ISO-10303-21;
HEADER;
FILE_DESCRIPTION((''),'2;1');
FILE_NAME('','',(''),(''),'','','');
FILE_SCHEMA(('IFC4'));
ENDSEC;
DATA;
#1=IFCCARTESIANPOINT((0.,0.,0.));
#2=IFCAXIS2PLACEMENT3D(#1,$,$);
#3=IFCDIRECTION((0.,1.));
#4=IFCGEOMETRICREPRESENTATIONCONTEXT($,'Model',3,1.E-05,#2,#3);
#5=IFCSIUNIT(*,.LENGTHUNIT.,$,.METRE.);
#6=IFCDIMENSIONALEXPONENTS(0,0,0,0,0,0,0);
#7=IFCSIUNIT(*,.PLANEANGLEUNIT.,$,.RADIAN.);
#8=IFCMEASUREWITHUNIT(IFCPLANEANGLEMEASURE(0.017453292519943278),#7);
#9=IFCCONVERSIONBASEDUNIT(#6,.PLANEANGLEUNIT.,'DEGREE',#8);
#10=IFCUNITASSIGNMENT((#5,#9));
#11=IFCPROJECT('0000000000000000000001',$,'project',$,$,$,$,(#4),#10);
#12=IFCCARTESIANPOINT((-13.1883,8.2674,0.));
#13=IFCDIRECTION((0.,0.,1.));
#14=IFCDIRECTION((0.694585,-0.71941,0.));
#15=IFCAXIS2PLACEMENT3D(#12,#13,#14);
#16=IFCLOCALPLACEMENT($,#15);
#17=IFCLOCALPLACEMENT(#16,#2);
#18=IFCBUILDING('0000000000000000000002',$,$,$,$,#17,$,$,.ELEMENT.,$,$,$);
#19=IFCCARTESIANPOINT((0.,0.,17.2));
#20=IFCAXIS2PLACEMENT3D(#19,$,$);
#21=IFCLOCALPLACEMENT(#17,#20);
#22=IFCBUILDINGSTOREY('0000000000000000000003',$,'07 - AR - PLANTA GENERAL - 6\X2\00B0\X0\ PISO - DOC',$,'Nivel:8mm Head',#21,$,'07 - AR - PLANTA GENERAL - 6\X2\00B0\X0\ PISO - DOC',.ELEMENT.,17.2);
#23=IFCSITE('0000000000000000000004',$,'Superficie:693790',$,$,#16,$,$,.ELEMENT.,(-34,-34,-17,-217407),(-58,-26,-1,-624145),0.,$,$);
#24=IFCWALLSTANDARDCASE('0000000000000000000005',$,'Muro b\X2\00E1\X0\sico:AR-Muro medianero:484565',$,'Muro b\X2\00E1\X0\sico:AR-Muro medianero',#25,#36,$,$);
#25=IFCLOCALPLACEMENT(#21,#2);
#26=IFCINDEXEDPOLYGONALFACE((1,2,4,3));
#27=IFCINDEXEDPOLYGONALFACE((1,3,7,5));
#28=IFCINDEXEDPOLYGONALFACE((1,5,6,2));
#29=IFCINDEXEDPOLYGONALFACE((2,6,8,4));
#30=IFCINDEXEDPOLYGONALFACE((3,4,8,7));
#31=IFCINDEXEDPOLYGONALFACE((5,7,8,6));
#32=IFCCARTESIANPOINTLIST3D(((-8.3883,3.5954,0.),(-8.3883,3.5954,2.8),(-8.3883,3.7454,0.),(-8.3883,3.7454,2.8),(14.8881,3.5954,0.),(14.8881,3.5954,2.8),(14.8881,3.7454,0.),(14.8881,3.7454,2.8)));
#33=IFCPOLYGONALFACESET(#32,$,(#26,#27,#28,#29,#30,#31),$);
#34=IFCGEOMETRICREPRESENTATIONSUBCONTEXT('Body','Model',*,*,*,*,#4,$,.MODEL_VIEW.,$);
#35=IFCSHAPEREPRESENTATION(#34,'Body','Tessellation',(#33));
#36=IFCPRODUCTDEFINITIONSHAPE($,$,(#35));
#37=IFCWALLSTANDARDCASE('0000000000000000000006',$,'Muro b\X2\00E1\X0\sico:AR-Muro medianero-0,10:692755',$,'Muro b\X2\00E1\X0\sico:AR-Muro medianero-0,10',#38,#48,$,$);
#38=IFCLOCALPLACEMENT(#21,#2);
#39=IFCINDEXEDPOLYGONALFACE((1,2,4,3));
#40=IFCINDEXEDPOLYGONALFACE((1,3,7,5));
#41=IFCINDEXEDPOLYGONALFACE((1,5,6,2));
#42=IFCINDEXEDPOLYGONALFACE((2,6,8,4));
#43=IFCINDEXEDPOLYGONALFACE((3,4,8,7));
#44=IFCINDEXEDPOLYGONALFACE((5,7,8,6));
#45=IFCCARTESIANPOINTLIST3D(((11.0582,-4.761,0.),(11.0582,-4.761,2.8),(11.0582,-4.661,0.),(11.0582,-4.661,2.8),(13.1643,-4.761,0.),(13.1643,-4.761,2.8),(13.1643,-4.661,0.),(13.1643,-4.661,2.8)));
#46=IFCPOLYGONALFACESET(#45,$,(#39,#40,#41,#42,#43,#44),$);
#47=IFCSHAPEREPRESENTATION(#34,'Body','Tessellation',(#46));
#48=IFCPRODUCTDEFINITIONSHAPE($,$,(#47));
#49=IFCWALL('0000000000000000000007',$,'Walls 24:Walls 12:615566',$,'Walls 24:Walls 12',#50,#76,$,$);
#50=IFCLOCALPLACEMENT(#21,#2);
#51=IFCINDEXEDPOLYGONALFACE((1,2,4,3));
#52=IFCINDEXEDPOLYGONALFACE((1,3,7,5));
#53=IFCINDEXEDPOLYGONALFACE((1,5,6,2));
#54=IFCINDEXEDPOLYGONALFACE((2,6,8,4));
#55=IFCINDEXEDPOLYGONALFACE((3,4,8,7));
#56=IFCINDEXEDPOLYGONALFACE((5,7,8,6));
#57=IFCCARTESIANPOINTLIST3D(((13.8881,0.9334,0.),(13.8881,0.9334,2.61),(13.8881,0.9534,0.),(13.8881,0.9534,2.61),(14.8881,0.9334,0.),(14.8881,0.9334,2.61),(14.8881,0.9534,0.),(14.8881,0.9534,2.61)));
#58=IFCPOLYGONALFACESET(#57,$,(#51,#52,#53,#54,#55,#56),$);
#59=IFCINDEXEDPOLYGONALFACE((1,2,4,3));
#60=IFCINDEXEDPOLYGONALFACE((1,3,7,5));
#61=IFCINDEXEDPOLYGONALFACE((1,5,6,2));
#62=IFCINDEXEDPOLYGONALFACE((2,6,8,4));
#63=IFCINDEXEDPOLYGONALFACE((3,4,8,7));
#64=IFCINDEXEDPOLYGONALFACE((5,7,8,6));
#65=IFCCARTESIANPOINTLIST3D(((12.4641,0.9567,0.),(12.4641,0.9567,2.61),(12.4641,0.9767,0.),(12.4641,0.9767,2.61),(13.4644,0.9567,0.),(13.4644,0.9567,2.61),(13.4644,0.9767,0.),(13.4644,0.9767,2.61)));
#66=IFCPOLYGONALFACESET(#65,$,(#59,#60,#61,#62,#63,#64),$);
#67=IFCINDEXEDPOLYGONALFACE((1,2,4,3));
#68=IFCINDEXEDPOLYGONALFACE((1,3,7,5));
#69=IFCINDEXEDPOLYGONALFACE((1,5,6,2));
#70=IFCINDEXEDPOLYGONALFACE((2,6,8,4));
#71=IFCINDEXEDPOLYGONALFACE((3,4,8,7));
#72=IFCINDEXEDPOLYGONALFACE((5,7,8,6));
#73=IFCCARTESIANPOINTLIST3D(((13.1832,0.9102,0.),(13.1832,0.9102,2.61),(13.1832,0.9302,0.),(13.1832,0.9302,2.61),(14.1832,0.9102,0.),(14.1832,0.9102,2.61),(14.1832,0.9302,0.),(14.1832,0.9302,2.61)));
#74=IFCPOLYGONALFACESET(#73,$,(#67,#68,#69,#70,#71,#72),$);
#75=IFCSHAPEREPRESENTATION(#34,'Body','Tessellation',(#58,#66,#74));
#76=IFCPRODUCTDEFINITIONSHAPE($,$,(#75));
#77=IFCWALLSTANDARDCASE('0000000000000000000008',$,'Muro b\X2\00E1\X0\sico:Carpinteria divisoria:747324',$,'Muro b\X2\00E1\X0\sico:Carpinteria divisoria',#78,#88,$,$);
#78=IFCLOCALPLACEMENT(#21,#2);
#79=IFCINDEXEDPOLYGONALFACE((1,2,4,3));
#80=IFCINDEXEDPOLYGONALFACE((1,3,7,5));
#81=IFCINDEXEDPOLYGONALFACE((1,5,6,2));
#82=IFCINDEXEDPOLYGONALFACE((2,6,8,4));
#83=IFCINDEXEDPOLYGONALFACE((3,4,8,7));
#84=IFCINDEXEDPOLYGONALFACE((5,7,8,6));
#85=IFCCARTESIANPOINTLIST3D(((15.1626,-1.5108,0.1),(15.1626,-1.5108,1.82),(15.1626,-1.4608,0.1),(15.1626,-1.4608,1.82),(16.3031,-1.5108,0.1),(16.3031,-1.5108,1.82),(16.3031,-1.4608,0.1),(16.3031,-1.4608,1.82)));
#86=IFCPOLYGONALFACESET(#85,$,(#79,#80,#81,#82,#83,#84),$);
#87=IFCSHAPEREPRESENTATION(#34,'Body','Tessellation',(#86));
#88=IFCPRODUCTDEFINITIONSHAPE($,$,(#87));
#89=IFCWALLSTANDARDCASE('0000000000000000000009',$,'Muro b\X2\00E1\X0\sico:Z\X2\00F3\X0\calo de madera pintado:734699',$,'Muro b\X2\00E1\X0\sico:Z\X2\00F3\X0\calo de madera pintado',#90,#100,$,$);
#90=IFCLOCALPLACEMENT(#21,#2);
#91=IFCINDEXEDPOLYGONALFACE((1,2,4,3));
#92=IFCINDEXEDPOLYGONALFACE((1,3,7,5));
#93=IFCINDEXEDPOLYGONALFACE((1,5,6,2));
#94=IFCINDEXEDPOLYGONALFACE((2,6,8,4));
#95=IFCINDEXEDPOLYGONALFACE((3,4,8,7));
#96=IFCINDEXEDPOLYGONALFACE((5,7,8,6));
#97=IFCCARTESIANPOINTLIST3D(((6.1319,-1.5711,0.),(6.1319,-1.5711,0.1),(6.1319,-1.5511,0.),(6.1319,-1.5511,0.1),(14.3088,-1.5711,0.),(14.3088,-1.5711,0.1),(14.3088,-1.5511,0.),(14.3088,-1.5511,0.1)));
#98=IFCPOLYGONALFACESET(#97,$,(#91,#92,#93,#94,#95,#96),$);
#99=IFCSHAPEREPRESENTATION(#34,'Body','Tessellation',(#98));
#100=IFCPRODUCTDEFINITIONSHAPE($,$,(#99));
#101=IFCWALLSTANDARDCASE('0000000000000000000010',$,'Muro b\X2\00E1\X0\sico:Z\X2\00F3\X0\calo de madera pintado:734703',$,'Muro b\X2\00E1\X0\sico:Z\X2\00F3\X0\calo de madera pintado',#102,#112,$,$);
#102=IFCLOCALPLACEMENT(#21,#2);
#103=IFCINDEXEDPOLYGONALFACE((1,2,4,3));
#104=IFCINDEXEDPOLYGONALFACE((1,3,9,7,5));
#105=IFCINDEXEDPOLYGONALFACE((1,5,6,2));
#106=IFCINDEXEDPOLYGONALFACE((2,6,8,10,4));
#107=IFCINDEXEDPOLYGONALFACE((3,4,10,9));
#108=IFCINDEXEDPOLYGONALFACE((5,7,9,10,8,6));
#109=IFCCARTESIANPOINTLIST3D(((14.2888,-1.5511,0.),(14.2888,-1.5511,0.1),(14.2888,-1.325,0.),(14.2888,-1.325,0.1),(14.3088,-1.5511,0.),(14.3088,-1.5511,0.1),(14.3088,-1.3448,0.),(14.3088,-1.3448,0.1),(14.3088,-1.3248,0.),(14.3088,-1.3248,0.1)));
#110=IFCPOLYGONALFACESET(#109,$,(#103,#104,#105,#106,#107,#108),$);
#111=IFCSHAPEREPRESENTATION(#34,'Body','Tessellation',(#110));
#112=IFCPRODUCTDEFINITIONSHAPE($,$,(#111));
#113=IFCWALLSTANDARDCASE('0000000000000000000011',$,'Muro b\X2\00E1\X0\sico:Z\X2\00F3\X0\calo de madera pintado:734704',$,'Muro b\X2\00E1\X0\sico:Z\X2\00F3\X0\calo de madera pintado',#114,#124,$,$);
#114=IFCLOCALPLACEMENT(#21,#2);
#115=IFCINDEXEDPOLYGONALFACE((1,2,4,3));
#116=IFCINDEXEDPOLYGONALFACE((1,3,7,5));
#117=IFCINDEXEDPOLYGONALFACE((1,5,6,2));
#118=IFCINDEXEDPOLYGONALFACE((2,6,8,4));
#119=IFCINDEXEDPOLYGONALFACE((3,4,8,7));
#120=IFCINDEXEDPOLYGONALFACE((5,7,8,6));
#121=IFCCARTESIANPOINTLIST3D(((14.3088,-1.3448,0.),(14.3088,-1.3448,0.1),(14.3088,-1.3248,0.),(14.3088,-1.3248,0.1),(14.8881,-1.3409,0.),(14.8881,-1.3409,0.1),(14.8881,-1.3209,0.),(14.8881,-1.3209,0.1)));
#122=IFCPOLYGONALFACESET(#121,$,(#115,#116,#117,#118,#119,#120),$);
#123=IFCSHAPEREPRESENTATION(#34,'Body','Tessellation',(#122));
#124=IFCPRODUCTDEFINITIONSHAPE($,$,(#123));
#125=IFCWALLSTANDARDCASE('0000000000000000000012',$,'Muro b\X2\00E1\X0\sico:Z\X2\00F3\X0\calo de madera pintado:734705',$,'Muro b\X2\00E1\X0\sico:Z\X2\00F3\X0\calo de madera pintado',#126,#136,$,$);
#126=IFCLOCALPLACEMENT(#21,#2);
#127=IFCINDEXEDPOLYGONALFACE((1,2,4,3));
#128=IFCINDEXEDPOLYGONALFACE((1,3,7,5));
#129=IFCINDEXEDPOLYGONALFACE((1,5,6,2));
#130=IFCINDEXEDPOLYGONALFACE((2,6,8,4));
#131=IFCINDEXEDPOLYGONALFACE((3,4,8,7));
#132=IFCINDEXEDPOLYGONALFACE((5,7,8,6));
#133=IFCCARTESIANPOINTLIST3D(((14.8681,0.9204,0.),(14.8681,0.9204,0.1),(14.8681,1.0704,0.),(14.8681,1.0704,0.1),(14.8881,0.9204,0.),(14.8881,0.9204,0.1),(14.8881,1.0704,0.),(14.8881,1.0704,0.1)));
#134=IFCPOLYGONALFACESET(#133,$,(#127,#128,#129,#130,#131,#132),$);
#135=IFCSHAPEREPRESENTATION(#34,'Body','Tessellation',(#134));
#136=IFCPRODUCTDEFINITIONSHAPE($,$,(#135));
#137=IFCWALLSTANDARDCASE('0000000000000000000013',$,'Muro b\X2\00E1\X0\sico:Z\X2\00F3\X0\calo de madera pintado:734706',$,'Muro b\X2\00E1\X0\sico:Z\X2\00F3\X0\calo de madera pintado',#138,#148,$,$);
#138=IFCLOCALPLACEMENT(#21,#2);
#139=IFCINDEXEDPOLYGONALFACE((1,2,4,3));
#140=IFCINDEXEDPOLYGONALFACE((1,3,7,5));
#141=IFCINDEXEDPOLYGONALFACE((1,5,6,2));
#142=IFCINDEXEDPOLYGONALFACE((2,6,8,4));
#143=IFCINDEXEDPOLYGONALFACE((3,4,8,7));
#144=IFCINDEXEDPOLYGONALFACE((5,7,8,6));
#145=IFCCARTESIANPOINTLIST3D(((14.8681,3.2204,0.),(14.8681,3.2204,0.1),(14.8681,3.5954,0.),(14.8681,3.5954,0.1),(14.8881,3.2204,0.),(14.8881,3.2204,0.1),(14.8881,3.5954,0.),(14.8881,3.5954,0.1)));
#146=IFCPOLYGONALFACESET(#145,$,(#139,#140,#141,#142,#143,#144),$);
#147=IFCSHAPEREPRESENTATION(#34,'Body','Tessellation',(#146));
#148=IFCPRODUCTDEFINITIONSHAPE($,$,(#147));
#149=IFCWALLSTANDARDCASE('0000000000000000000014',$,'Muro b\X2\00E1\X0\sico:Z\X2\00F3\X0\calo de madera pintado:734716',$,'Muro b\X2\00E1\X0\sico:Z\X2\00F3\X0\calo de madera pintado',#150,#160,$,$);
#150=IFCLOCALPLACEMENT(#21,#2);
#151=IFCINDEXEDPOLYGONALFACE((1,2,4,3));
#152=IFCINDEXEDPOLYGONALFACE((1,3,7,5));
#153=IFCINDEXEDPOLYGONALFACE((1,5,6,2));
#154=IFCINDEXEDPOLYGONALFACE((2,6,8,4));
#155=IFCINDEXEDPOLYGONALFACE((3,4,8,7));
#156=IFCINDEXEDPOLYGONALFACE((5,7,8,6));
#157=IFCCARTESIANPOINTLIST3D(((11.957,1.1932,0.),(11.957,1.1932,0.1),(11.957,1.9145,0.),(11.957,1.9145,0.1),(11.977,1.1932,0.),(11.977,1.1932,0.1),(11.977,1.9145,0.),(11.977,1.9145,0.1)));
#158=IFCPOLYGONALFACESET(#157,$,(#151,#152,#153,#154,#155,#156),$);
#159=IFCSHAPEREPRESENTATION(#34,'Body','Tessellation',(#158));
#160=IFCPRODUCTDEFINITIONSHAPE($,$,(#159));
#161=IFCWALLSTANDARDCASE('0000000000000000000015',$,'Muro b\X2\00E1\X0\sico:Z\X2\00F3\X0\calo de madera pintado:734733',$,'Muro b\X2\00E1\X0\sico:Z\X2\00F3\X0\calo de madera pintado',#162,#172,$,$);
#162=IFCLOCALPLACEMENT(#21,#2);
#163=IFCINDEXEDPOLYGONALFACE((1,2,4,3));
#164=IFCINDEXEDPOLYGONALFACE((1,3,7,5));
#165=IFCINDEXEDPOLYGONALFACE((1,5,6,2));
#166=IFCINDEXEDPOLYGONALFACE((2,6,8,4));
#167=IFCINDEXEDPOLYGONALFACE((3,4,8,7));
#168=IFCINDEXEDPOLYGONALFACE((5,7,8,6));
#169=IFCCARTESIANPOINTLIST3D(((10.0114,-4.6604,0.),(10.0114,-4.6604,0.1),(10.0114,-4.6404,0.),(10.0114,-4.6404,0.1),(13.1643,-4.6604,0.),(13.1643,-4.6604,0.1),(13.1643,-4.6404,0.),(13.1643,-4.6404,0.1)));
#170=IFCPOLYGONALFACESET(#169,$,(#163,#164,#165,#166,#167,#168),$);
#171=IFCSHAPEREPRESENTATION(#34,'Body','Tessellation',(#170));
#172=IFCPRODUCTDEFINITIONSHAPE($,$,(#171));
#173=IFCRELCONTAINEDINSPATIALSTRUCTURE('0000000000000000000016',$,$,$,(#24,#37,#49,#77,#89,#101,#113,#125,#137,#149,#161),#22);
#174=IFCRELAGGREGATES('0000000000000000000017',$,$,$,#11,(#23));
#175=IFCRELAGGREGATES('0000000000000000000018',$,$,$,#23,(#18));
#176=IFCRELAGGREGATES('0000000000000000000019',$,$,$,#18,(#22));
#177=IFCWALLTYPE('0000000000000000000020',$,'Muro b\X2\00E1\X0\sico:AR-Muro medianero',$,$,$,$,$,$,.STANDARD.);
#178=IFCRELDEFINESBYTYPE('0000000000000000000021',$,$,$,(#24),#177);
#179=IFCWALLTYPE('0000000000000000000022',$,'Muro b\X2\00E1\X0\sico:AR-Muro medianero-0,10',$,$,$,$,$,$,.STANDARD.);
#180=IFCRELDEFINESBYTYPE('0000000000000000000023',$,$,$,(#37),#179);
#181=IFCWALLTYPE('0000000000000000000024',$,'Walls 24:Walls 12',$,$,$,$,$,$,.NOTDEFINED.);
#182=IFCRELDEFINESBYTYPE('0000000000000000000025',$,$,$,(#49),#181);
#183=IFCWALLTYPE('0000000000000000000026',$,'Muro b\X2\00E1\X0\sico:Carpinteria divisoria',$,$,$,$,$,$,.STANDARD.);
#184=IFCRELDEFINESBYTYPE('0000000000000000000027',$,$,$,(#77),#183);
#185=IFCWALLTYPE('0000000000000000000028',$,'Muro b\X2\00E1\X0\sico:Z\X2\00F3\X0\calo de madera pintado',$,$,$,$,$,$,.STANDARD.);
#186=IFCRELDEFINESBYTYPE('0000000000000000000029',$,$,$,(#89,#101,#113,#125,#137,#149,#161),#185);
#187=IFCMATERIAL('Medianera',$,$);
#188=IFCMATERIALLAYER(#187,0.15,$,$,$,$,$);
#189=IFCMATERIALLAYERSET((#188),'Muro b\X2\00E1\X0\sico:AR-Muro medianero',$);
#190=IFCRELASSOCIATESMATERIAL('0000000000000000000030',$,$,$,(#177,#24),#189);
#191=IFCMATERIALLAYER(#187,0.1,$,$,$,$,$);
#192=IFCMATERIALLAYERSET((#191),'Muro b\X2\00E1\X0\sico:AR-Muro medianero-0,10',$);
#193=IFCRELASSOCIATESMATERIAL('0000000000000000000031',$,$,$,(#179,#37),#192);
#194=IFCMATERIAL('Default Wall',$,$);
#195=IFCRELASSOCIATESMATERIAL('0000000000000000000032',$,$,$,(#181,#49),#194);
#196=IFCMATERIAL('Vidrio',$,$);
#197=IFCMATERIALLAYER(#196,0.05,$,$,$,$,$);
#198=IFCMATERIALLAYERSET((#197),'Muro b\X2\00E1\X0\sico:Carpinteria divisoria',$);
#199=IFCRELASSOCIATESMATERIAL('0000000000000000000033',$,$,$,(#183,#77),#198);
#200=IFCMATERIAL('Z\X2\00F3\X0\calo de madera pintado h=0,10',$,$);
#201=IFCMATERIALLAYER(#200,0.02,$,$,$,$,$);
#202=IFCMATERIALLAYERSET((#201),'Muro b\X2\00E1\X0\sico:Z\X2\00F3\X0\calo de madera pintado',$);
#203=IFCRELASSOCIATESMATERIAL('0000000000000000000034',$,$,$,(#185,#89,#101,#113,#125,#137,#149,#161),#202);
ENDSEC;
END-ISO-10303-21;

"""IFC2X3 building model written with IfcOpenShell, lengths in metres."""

from ifc_helpers import new_model, entity, si_unit, converted_unit, direction, frame, frame_2d, origin, origin_2d_with_axis, place, context, subcontext, project, spatial, polyline, rectangle, outline, extrude, material, layer, layer_set, layer_usage, type_object, element, save


model = new_model("IFC2X3")

# Units and contexts
model_context = context("Model", 3, precision=1e-05, world=origin(), true_north=direction((0.0, 1.0)))
body_context = subcontext(model_context, "Body", "Model", "MODEL_VIEW")
ifc_project = project(units=[si_unit("LENGTHUNIT", "METRE"), converted_unit("PLANEANGLEUNIT", "DEGREE", entity("IfcPlaneAngleMeasure", 0.017453292519943278), si_unit("PLANEANGLEUNIT", "RADIAN"), dimensions=[0, 0, 0, 0, 0, 0, 0])], contexts=[model_context])

# Site, building, storey
site_placement = place(None, frame((-13.1883, 8.2674, 0.0), z_axis=(0.0, 0.0, 1.0), x_axis=(0.694585, -0.71941, 0.0)))
site = spatial("IfcSite", under=ifc_project, at=site_placement, Name="Superficie:693790", CompositionType="ELEMENT", RefLatitude=(-34, -34, -17, -217407), RefLongitude=(-58, -26, -1, -624145), RefElevation=0.0)
building_placement = place(site_placement, origin())
building = spatial("IfcBuilding", under=site, at=building_placement, CompositionType="ELEMENT")
storey_placement = place(building_placement, frame((0.0, 0.0, 17.2)))
storey = spatial("IfcBuildingStorey", under=building, at=storey_placement, Name="07 - AR - PLANTA GENERAL - 6° PISO - DOC", ObjectType="Nivel:8mm Head", LongName="07 - AR - PLANTA GENERAL - 6° PISO - DOC", CompositionType="ELEMENT", Elevation=17.2)

# Shared definitions
ifc_material_1 = material(Name="Vidrio")

# Walls
ifc_material_2 = material(Name="Medianera")
ifc_layer_1 = layer(ifc_material_2, 0.15)
ifc_layer_set_1 = layer_set([ifc_layer_1], Name="Muro básico:AR-Muro medianero")
ifc_layer_usage_1 = layer_usage(ifc_layer_set_1, "AXIS2", "NEGATIVE", 0.075)
wall_type_1 = type_object("IfcWallType", Name="Muro básico:AR-Muro medianero", PredefinedType="STANDARD", material=ifc_layer_set_1)
wall_1_placement = place(storey_placement, frame((14.8881, 3.6704, 0.0), z_axis=(0.0, 0.0, 1.0), x_axis=(-1.0, 0.0, 0.0)))
element("IfcWallStandardCase", 1, at=wall_1_placement, inside=storey, type_object=wall_type_1, material=ifc_layer_usage_1, Name="Muro básico:AR-Muro medianero:484565", ObjectType="Muro básico:AR-Muro medianero", context=body_context, shape_type="SweptSolid", body=[
    extrude(rectangle(XDim=23.2763, YDim=0.15, at=frame_2d((11.6382, 0.0), x_axis=(-1.0, 0.0))), origin(), (0.0, 0.0, 1.0), 2.8),
])
ifc_layer_2 = layer(ifc_material_2, 0.1)
ifc_layer_set_2 = layer_set([ifc_layer_2], Name="Muro básico:AR-Muro medianero-0,10")
ifc_layer_usage_2 = layer_usage(ifc_layer_set_2, "AXIS2", "POSITIVE", -0.05)
wall_type_2 = type_object("IfcWallType", Name="Muro básico:AR-Muro medianero-0,10", PredefinedType="STANDARD", material=ifc_layer_set_2)
wall_2_placement = place(storey_placement, frame((13.1643, -4.711, 0.0), z_axis=(0.0, 0.0, 1.0), x_axis=(-1.0, 0.0, 0.0)))
element("IfcWallStandardCase", 2, at=wall_2_placement, inside=storey, type_object=wall_type_2, material=ifc_layer_usage_2, Name="Muro básico:AR-Muro medianero-0,10:692755", ObjectType="Muro básico:AR-Muro medianero-0,10", context=body_context, shape_type="SweptSolid", body=[
    extrude(rectangle(XDim=2.1061, YDim=0.1, at=frame_2d((1.053, 0.0), x_axis=(-1.0, 0.0))), origin(), (0.0, 0.0, 1.0), 2.8),
])
ifc_material_3 = material(Name="Default Wall")
wall_type_3 = type_object("IfcWallType", Name="Walls 24:Walls 12", PredefinedType="NOTDEFINED", material=ifc_material_3)
wall_3_placement = place(storey_placement, frame((12.4641, 0.9102, 0.0)))
element("IfcWall", 3, at=wall_3_placement, inside=storey, type_object=wall_type_3, material=ifc_material_3, Name="Walls 24:Walls 12:615566", ObjectType="Walls 24:Walls 12", context=body_context, shape_type="SweptSolid", body=[
    extrude(rectangle(XDim=1.0, YDim=0.02, at=origin_2d_with_axis()), frame((1.9239, 0.0332, 0.0), z_axis=(0.0, 0.0, 1.0), x_axis=(-1.0, 0.0, 0.0)), (0.0, 0.0, 1.0), 2.61),
    extrude(rectangle(XDim=1.0003, YDim=0.02, at=frame_2d((0.0, 0.0), x_axis=(1.0, 0.0))), frame((0.5001, 0.0565, 0.0), z_axis=(0.0, 0.0, 1.0), x_axis=(-1.0, 0.0, 0.0)), (0.0, 0.0, 1.0), 2.61),
    extrude(rectangle(XDim=1.0, YDim=0.02, at=origin_2d_with_axis()), frame((1.2191, 0.01, 0.0), z_axis=(0.0, 0.0, 1.0), x_axis=(-1.0, 0.0, 0.0)), (0.0, 0.0, 1.0), 2.61),
])
ifc_layer_3 = layer(ifc_material_1, 0.05)
ifc_layer_set_3 = layer_set([ifc_layer_3], Name="Muro básico:Carpinteria divisoria")
ifc_layer_usage_3 = layer_usage(ifc_layer_set_3, "AXIS2", "NEGATIVE", 0.025)
wall_type_4 = type_object("IfcWallType", Name="Muro básico:Carpinteria divisoria", PredefinedType="STANDARD", material=ifc_layer_set_3)
wall_4_placement = place(storey_placement, frame((15.1626, -1.4858, 0.1)))
element("IfcWallStandardCase", 4, at=wall_4_placement, inside=storey, type_object=wall_type_4, material=ifc_layer_usage_3, Name="Muro básico:Carpinteria divisoria:747324", ObjectType="Muro básico:Carpinteria divisoria", context=body_context, shape_type="SweptSolid", body=[
    extrude(rectangle(XDim=1.1405, YDim=0.05, at=frame_2d((0.5702, 0.0), x_axis=(-1.0, 0.0))), origin(), (0.0, 0.0, 1.0), 1.72),
])
ifc_material_4 = material(Name="Zócalo de madera pintado h=0,10")
ifc_layer_4 = layer(ifc_material_4, 0.02)
ifc_layer_set_4 = layer_set([ifc_layer_4], Name="Muro básico:Zócalo de madera pintado")
ifc_layer_usage_4 = layer_usage(ifc_layer_set_4, "AXIS2", "NEGATIVE", 0.01)
wall_type_5 = type_object("IfcWallType", Name="Muro básico:Zócalo de madera pintado", PredefinedType="STANDARD", material=ifc_layer_set_4)
wall_5_placement = place(storey_placement, frame((14.3088, -1.5611, 0.0), z_axis=(0.0, 0.0, 1.0), x_axis=(-1.0, 0.0, 0.0)))
element("IfcWallStandardCase", 5, at=wall_5_placement, inside=storey, type_object=wall_type_5, material=ifc_layer_usage_4, Name="Muro básico:Zócalo de madera pintado:734699", ObjectType="Muro básico:Zócalo de madera pintado", context=body_context, shape_type="SweptSolid", body=[
    extrude(rectangle(XDim=8.177, YDim=0.02, at=frame_2d((4.0885, 0.0), x_axis=(-1.0, 0.0))), origin(), (0.0, 0.0, 1.0), 0.1),
])
ifc_layer_usage_5 = layer_usage(ifc_layer_set_4, "AXIS2", "NEGATIVE", 0.01)
wall_6_placement = place(storey_placement, frame((14.2988, -1.3248, 0.0), z_axis=(0.0, 0.0, 1.0), x_axis=(0.0, -1.0, 0.0)))
element("IfcWallStandardCase", 6, at=wall_6_placement, inside=storey, type_object=wall_type_5, material=ifc_layer_usage_5, Name="Muro básico:Zócalo de madera pintado:734703", ObjectType="Muro básico:Zócalo de madera pintado", context=body_context, shape_type="SweptSolid", body=[
    extrude(outline(polyline([(0.2262, -0.01), (0.2262, 0.01), (0.02, 0.01), (0.0, 0.01), (0.0001, -0.01), (0.2262, -0.01)])), origin(), (0.0, 0.0, 1.0), 0.1),
])
ifc_layer_usage_6 = layer_usage(ifc_layer_set_4, "AXIS2", "NEGATIVE", 0.01)
wall_7_placement = place(storey_placement, frame((14.8881, -1.3309, 0.0), z_axis=(0.0, 0.0, 1.0), x_axis=(-0.999977, -0.006798, 0.0)))
element("IfcWallStandardCase", 7, at=wall_7_placement, inside=storey, type_object=wall_type_5, material=ifc_layer_usage_6, Name="Muro básico:Zócalo de madera pintado:734704", ObjectType="Muro básico:Zócalo de madera pintado", context=body_context, shape_type="SweptSolid", body=[
    extrude(outline(polyline([(0.5792, -0.01), (0.5794, 0.01), (0.0001, 0.01), (0.0, -0.01), (0.5792, -0.01)])), origin(), (0.0, 0.0, 1.0), 0.1),
])
ifc_layer_usage_7 = layer_usage(ifc_layer_set_4, "AXIS2", "NEGATIVE", 0.01)
wall_8_placement = place(storey_placement, frame((14.8781, 1.0704, 0.0), z_axis=(0.0, 0.0, 1.0), x_axis=(0.0, -1.0, 0.0)))
element("IfcWallStandardCase", 8, at=wall_8_placement, inside=storey, type_object=wall_type_5, material=ifc_layer_usage_7, Name="Muro básico:Zócalo de madera pintado:734705", ObjectType="Muro básico:Zócalo de madera pintado", context=body_context, shape_type="SweptSolid", body=[
    extrude(rectangle(XDim=0.15, YDim=0.02, at=frame_2d((0.075, 0.0), x_axis=(-1.0, 0.0))), origin(), (0.0, 0.0, 1.0), 0.1),
])
ifc_layer_usage_8 = layer_usage(ifc_layer_set_4, "AXIS2", "NEGATIVE", 0.01)
wall_9_placement = place(storey_placement, frame((14.8781, 3.5954, 0.0), z_axis=(0.0, 0.0, 1.0), x_axis=(0.0, -1.0, 0.0)))
element("IfcWallStandardCase", 9, at=wall_9_placement, inside=storey, type_object=wall_type_5, material=ifc_layer_usage_8, Name="Muro básico:Zócalo de madera pintado:734706", ObjectType="Muro básico:Zócalo de madera pintado", context=body_context, shape_type="SweptSolid", body=[
    extrude(rectangle(XDim=0.375, YDim=0.02, at=frame_2d((0.1875, 0.0), x_axis=(-1.0, 0.0))), origin(), (0.0, 0.0, 1.0), 0.1),
])
ifc_layer_usage_9 = layer_usage(ifc_layer_set_4, "AXIS2", "NEGATIVE", 0.01)
wall_10_placement = place(storey_placement, frame((11.967, 1.1932, 0.0), z_axis=(0.0, 0.0, 1.0), x_axis=(0.0, 1.0, 0.0)))
element("IfcWallStandardCase", 10, at=wall_10_placement, inside=storey, type_object=wall_type_5, material=ifc_layer_usage_9, Name="Muro básico:Zócalo de madera pintado:734716", ObjectType="Muro básico:Zócalo de madera pintado", context=body_context, shape_type="SweptSolid", body=[
    extrude(rectangle(XDim=0.7214, YDim=0.02, at=frame_2d((0.3607, 0.0), x_axis=(-1.0, 0.0))), origin(), (0.0, 0.0, 1.0), 0.1),
])
ifc_layer_usage_10 = layer_usage(ifc_layer_set_4, "AXIS2", "NEGATIVE", 0.01)
wall_11_placement = place(storey_placement, frame((13.1643, -4.6504, 0.0), z_axis=(0.0, 0.0, 1.0), x_axis=(-1.0, 0.0, 0.0)))
element("IfcWallStandardCase", 11, at=wall_11_placement, inside=storey, type_object=wall_type_5, material=ifc_layer_usage_10, Name="Muro básico:Zócalo de madera pintado:734733", ObjectType="Muro básico:Zócalo de madera pintado", context=body_context, shape_type="SweptSolid", body=[
    extrude(rectangle(XDim=3.1529, YDim=0.02, at=frame_2d((1.5765, 0.0), x_axis=(-1.0, 0.0))), origin(), (0.0, 0.0, 1.0), 0.1),
])

save(model, "model.ifc")
